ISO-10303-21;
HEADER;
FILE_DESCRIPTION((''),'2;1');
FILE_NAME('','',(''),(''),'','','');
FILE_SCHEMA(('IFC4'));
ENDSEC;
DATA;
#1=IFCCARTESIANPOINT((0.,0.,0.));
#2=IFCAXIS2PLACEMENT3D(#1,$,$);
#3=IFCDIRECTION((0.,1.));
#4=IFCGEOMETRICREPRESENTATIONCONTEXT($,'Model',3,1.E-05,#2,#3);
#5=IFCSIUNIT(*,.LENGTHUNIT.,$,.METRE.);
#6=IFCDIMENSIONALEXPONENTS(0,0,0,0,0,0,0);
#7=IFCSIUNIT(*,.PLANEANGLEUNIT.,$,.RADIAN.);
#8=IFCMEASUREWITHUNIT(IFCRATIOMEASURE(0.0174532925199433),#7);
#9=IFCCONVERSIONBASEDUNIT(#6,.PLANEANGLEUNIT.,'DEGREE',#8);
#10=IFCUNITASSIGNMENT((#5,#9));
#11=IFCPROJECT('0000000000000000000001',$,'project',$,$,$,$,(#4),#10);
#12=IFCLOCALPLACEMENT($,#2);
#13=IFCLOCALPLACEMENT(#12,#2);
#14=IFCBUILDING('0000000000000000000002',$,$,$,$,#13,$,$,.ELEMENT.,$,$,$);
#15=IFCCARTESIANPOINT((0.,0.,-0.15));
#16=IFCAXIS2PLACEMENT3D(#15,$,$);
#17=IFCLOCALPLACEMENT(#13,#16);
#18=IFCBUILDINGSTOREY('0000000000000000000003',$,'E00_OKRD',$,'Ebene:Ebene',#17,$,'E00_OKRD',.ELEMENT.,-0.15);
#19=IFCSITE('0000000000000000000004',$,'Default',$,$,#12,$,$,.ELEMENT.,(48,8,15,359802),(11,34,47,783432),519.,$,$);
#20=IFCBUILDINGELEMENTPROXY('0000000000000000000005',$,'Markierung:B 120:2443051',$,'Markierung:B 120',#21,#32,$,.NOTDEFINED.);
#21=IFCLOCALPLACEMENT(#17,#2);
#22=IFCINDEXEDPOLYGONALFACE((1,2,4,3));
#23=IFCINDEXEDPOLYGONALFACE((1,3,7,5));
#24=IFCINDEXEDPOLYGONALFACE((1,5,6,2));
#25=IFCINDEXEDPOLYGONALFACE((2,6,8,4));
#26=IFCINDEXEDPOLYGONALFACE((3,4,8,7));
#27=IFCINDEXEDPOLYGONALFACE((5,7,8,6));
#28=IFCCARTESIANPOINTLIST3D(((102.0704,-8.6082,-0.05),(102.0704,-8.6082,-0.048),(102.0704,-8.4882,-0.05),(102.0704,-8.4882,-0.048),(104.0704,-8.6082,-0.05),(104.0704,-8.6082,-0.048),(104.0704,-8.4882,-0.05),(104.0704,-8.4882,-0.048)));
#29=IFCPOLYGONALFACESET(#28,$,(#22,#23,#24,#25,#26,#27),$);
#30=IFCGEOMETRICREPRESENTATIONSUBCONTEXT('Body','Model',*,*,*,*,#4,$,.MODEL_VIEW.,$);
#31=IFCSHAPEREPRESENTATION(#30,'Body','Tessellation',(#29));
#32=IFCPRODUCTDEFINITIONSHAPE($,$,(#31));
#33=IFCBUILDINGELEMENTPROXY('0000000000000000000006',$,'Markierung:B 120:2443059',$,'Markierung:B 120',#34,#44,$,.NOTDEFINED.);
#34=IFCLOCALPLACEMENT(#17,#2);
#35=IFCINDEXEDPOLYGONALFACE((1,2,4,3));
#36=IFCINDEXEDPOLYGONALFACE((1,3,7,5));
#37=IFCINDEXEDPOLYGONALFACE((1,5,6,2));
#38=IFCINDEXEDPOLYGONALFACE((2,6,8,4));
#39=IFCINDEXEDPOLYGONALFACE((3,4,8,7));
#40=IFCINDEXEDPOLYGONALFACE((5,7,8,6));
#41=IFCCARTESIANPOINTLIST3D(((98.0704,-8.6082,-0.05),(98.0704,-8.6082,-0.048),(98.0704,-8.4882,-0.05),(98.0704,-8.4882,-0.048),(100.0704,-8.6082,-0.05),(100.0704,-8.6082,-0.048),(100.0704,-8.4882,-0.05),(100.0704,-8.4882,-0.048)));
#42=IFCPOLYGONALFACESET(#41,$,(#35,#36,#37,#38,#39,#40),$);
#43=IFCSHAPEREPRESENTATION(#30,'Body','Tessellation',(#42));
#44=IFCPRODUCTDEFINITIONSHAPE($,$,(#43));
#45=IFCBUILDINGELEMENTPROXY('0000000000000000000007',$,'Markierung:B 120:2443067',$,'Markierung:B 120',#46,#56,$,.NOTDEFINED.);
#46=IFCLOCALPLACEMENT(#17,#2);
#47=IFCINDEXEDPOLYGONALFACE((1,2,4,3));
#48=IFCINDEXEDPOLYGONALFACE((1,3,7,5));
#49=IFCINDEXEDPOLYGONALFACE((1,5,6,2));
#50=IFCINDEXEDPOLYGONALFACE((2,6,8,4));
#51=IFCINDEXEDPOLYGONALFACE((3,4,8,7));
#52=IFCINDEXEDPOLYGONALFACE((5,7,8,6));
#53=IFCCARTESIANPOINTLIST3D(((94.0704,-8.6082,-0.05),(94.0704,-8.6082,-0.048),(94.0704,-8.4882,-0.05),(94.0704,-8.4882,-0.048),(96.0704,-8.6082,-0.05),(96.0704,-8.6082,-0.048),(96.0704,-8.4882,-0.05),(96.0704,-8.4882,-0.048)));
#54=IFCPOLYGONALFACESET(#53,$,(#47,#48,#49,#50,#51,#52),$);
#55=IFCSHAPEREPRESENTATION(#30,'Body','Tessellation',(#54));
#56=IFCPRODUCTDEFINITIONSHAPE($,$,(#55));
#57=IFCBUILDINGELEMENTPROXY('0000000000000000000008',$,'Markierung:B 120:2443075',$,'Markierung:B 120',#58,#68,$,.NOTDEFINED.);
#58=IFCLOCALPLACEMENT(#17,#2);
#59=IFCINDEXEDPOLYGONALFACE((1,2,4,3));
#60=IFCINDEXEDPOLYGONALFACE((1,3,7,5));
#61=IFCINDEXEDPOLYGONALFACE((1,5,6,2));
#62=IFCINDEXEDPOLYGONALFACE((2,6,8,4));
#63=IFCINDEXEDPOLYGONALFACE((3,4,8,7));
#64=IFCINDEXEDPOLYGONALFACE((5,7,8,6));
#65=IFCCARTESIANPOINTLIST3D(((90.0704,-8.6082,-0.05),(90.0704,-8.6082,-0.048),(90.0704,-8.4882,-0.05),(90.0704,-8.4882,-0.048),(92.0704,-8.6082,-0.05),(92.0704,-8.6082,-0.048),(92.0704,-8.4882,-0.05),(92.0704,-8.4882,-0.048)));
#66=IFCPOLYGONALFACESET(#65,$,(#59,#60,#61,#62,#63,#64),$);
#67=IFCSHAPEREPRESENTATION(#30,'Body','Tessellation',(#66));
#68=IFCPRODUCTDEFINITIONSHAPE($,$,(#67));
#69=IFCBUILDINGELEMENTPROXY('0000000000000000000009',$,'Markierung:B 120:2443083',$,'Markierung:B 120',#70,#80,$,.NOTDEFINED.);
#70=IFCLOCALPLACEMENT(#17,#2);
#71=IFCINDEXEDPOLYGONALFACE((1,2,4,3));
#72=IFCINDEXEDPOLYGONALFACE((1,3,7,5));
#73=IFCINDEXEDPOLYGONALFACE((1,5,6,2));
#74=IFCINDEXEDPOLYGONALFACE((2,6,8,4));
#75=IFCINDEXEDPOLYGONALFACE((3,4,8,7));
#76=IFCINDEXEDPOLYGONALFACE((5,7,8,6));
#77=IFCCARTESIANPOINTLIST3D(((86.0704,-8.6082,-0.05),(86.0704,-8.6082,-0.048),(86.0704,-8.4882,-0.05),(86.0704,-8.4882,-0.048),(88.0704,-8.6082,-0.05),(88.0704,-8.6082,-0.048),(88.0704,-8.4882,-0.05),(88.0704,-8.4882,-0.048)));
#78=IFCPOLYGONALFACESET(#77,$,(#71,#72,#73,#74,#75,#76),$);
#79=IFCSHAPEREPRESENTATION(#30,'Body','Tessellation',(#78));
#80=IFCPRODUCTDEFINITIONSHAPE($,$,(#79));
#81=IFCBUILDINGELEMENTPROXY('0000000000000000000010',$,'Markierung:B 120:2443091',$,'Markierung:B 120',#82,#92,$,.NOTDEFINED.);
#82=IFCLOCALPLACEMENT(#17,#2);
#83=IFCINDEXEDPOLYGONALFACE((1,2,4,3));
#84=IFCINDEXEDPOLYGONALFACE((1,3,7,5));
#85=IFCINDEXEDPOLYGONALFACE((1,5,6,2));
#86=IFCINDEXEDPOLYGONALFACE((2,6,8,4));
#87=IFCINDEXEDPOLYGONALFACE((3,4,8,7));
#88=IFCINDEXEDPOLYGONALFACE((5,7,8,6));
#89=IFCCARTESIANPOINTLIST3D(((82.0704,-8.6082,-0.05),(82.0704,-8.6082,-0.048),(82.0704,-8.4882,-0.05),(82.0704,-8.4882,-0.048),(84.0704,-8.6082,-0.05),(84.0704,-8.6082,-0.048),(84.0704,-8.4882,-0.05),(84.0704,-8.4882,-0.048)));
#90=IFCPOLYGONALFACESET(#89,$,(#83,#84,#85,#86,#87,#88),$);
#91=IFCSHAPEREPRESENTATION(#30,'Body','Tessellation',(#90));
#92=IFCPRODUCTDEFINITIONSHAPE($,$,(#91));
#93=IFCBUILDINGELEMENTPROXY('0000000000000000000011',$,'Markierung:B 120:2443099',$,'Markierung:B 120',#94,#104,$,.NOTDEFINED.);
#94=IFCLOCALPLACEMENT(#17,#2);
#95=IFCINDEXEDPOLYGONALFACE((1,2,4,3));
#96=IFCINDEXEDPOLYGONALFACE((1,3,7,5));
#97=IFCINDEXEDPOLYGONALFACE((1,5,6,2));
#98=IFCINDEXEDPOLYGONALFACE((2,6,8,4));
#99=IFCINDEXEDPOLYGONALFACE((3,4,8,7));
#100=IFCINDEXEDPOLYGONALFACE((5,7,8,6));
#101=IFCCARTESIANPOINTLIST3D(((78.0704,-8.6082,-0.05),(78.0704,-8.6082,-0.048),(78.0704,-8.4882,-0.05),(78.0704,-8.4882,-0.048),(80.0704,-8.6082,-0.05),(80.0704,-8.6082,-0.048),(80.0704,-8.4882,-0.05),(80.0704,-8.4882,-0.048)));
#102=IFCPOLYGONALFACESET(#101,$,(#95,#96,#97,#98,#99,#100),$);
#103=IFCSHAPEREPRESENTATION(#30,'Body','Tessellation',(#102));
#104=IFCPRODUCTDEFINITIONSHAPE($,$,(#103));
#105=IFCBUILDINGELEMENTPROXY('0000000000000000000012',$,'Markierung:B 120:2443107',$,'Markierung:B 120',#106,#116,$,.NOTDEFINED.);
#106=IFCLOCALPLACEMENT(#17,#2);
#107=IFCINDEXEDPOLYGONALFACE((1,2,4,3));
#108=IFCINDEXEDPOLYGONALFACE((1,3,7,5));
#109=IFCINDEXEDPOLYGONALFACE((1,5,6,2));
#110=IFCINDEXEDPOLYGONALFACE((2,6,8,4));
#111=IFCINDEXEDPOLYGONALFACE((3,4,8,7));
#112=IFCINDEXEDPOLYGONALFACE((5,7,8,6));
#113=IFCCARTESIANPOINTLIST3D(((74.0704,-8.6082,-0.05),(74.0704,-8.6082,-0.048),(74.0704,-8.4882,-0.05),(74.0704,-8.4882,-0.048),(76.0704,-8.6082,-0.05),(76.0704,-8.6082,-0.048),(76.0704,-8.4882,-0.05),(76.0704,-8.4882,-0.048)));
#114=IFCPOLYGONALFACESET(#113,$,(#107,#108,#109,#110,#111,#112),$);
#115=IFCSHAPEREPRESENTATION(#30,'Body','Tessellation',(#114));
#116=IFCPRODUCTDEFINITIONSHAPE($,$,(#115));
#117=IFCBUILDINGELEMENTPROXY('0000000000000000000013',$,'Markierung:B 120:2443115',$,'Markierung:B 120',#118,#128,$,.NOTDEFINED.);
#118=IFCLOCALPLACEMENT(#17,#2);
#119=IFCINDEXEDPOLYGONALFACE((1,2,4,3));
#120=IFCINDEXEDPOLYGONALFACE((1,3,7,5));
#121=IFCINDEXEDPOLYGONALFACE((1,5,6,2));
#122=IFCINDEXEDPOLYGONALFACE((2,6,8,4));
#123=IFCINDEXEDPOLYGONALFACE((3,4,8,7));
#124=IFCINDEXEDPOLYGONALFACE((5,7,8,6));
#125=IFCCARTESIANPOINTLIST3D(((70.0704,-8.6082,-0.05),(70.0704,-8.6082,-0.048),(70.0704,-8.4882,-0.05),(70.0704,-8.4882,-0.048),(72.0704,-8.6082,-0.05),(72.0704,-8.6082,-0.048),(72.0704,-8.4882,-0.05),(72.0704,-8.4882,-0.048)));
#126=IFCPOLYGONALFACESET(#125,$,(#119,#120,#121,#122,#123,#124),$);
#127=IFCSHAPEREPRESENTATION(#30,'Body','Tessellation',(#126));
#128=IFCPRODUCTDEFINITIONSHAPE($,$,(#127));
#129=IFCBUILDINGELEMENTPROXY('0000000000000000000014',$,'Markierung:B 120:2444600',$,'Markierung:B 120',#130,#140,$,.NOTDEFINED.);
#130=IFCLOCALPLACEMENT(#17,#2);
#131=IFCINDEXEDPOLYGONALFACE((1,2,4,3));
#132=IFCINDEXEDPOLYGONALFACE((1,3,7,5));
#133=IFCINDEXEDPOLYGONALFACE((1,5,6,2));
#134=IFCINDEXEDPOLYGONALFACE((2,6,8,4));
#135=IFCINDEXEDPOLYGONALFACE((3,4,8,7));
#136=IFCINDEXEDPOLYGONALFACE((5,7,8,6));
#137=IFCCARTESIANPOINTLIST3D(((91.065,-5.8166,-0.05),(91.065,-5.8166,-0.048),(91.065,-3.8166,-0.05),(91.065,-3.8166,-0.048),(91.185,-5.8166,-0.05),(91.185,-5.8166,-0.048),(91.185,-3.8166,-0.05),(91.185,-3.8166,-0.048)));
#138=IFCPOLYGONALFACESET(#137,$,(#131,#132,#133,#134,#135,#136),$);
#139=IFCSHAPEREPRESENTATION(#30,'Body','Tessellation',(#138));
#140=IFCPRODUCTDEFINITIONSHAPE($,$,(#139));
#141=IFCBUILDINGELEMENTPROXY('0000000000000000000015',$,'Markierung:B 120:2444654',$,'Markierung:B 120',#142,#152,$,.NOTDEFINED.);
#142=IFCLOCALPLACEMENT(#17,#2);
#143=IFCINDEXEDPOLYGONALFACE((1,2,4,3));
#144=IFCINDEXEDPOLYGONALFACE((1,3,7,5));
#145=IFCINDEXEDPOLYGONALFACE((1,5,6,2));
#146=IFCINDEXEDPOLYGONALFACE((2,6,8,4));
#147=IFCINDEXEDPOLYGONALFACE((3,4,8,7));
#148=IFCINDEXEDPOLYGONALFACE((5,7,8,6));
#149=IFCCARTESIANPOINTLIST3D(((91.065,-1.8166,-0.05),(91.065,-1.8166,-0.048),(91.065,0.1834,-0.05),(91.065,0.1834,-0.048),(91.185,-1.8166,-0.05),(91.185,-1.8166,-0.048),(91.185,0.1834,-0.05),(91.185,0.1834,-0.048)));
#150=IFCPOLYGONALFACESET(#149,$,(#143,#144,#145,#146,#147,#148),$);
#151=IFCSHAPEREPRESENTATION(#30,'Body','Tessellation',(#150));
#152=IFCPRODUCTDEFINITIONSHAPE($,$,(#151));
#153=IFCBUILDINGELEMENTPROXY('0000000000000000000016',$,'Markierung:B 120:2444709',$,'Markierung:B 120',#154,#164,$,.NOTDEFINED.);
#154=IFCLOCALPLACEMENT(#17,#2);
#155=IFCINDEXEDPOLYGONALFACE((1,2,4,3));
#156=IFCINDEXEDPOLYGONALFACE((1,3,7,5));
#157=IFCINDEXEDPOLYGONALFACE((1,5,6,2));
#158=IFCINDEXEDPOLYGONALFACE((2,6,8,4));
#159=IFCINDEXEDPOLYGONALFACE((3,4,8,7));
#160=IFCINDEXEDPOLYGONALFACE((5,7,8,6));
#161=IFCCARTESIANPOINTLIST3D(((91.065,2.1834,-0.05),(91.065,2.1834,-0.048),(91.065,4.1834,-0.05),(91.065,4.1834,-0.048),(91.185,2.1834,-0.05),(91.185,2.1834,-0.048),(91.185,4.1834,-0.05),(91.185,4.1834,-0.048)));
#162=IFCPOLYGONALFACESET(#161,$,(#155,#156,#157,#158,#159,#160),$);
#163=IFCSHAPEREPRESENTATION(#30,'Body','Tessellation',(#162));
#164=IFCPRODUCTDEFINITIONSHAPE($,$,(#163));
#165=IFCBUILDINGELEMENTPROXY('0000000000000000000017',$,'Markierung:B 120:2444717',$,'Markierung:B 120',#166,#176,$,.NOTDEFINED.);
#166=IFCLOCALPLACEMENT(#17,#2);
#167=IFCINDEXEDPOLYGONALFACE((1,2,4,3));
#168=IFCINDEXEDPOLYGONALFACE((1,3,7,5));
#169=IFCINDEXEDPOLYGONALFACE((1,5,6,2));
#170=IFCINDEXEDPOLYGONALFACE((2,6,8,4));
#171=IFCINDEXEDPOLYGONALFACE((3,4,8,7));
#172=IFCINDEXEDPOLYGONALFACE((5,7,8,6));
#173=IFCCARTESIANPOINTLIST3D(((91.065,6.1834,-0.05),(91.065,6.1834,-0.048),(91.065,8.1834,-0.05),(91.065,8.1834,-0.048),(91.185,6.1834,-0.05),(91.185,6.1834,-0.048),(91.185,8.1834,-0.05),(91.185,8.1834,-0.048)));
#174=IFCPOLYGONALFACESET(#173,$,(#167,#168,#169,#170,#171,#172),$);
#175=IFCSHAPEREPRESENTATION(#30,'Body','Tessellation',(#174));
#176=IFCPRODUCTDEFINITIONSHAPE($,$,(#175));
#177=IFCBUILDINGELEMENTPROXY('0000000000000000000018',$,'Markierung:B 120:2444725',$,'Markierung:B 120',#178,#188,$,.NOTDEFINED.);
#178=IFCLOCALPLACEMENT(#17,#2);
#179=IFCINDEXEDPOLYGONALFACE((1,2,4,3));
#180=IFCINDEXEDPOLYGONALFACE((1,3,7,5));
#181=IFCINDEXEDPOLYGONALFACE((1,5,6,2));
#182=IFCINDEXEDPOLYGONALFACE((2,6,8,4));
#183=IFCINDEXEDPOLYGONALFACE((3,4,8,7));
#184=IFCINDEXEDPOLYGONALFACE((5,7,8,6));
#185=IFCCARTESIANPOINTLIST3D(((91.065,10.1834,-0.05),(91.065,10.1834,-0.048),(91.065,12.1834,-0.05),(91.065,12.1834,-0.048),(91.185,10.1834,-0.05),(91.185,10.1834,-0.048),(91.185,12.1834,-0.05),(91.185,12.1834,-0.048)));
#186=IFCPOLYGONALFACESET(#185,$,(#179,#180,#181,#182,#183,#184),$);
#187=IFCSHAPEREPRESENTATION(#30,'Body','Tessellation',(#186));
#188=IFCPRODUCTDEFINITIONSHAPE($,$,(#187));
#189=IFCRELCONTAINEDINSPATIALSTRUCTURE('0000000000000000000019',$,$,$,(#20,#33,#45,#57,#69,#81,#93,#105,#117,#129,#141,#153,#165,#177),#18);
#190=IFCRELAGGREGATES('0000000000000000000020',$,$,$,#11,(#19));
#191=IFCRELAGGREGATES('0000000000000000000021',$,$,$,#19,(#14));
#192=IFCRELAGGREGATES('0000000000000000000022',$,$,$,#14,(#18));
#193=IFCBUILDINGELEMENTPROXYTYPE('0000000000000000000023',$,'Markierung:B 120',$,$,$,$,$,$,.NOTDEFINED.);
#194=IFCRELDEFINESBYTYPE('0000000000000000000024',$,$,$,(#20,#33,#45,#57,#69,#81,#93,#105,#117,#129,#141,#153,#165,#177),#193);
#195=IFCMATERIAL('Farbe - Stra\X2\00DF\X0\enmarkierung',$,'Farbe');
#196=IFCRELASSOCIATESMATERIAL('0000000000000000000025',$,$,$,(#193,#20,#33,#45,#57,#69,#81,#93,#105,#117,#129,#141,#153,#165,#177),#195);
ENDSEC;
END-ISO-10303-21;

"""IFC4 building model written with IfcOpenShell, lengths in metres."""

from ifc_helpers import new_model, entity, si_unit, converted_unit, direction, frame, frame_2d, origin, place, context, subcontext, project, spatial, rectangle, extrude, source, transform, mapped, material, type_object, type_shapes, element, save


model = new_model("IFC4")

# Units and contexts
model_context = context("Model", 3, precision=1e-05, world=origin(), true_north=direction((0.0, 1.0)))
body_context = subcontext(model_context, "Body", "Model", "MODEL_VIEW")
ifc_project = project(units=[si_unit("LENGTHUNIT", "METRE"), converted_unit("PLANEANGLEUNIT", "DEGREE", entity("IfcRatioMeasure", 0.0174532925199433), si_unit("PLANEANGLEUNIT", "RADIAN"), dimensions=[0, 0, 0, 0, 0, 0, 0])], contexts=[model_context])

# Site, building, storey
site_placement = place(None, frame((0.0, 0.0, 0.0)))
site = spatial("IfcSite", under=ifc_project, at=site_placement, Name="Default", CompositionType="ELEMENT", RefLatitude=(48, 8, 15, 359802), RefLongitude=(11, 34, 47, 783432), RefElevation=519.0)
building_placement = place(site_placement, origin())
building = spatial("IfcBuilding", under=site, at=building_placement, CompositionType="ELEMENT")
storey_placement = place(building_placement, frame((0.0, 0.0, -0.15)))
storey = spatial("IfcBuildingStorey", under=building, at=storey_placement, Name="E00_OKRD", ObjectType="Ebene:Ebene", LongName="E00_OKRD", CompositionType="ELEMENT", Elevation=-0.15)

# Building element proxies
ifc_material_1 = material(Name="Farbe - Straßenmarkierung", Category="Farbe")
building_element_proxy_type_1 = type_object("IfcBuildingElementProxyType", Name="Markierung:B 120", PredefinedType="NOTDEFINED", material=ifc_material_1)
shared_shape_1 = source(origin(), body_context, "Body", "SweptSolid", [
    extrude(rectangle(XDim=0.12, YDim=2.0, at=frame_2d((0.0, 0.0), x_axis=(1.0, 0.0))), frame((0.06, 1.0, 0.0), z_axis=(0.0, 0.0, 1.0), x_axis=(-1.0, 0.0, 0.0)), (0.0, 0.0, 1.0), 0.002),
])
type_shapes(building_element_proxy_type_1, [shared_shape_1])
for number, where, z_axis, x_axis, name in (
    (1, (104.0704, -8.6082, -0.05), (0.0, 0.0, 1.0), (0.0, 1.0, 0.0), "Markierung:B 120:2443051"),
    (2, (100.0704, -8.6082, -0.05), (0.0, 0.0, 1.0), (0.0, 1.0, 0.0), "Markierung:B 120:2443059"),
    (3, (96.0704, -8.6082, -0.05), (0.0, 0.0, 1.0), (0.0, 1.0, 0.0), "Markierung:B 120:2443067"),
    (4, (92.0704, -8.6082, -0.05), (0.0, 0.0, 1.0), (0.0, 1.0, 0.0), "Markierung:B 120:2443075"),
    (5, (88.0704, -8.6082, -0.05), (0.0, 0.0, 1.0), (0.0, 1.0, 0.0), "Markierung:B 120:2443083"),
    (6, (84.0704, -8.6082, -0.05), (0.0, 0.0, 1.0), (0.0, 1.0, 0.0), "Markierung:B 120:2443091"),
    (7, (80.0704, -8.6082, -0.05), (0.0, 0.0, 1.0), (0.0, 1.0, 0.0), "Markierung:B 120:2443099"),
    (8, (76.0704, -8.6082, -0.05), (0.0, 0.0, 1.0), (0.0, 1.0, 0.0), "Markierung:B 120:2443107"),
    (9, (72.0704, -8.6082, -0.05), (0.0, 0.0, 1.0), (0.0, 1.0, 0.0), "Markierung:B 120:2443115"),
):
    element("IfcBuildingElementProxy", number, at=place(storey_placement, frame(where, z_axis=z_axis, x_axis=x_axis)), inside=storey, type_object=building_element_proxy_type_1, material=ifc_material_1, Name=name, ObjectType="Markierung:B 120", PredefinedType="NOTDEFINED", context=body_context, shape_type="MappedRepresentation", body=[
        mapped(shared_shape_1, transform((0.0, 0.0, 0.0), scale=1.0)),
    ])
for number, where, name in (
    (10, (91.065, -5.8166, -0.05), "Markierung:B 120:2444600"),
    (11, (91.065, -1.8166, -0.05), "Markierung:B 120:2444654"),
    (12, (91.065, 2.1834, -0.05), "Markierung:B 120:2444709"),
    (13, (91.065, 6.1834, -0.05), "Markierung:B 120:2444717"),
    (14, (91.065, 10.1834, -0.05), "Markierung:B 120:2444725"),
):
    element("IfcBuildingElementProxy", number, at=place(storey_placement, frame(where)), inside=storey, type_object=building_element_proxy_type_1, material=ifc_material_1, Name=name, ObjectType="Markierung:B 120", PredefinedType="NOTDEFINED", context=body_context, shape_type="MappedRepresentation", body=[
        mapped(shared_shape_1, transform((0.0, 0.0, 0.0), scale=1.0)),
    ])

save(model, "model.ifc")
